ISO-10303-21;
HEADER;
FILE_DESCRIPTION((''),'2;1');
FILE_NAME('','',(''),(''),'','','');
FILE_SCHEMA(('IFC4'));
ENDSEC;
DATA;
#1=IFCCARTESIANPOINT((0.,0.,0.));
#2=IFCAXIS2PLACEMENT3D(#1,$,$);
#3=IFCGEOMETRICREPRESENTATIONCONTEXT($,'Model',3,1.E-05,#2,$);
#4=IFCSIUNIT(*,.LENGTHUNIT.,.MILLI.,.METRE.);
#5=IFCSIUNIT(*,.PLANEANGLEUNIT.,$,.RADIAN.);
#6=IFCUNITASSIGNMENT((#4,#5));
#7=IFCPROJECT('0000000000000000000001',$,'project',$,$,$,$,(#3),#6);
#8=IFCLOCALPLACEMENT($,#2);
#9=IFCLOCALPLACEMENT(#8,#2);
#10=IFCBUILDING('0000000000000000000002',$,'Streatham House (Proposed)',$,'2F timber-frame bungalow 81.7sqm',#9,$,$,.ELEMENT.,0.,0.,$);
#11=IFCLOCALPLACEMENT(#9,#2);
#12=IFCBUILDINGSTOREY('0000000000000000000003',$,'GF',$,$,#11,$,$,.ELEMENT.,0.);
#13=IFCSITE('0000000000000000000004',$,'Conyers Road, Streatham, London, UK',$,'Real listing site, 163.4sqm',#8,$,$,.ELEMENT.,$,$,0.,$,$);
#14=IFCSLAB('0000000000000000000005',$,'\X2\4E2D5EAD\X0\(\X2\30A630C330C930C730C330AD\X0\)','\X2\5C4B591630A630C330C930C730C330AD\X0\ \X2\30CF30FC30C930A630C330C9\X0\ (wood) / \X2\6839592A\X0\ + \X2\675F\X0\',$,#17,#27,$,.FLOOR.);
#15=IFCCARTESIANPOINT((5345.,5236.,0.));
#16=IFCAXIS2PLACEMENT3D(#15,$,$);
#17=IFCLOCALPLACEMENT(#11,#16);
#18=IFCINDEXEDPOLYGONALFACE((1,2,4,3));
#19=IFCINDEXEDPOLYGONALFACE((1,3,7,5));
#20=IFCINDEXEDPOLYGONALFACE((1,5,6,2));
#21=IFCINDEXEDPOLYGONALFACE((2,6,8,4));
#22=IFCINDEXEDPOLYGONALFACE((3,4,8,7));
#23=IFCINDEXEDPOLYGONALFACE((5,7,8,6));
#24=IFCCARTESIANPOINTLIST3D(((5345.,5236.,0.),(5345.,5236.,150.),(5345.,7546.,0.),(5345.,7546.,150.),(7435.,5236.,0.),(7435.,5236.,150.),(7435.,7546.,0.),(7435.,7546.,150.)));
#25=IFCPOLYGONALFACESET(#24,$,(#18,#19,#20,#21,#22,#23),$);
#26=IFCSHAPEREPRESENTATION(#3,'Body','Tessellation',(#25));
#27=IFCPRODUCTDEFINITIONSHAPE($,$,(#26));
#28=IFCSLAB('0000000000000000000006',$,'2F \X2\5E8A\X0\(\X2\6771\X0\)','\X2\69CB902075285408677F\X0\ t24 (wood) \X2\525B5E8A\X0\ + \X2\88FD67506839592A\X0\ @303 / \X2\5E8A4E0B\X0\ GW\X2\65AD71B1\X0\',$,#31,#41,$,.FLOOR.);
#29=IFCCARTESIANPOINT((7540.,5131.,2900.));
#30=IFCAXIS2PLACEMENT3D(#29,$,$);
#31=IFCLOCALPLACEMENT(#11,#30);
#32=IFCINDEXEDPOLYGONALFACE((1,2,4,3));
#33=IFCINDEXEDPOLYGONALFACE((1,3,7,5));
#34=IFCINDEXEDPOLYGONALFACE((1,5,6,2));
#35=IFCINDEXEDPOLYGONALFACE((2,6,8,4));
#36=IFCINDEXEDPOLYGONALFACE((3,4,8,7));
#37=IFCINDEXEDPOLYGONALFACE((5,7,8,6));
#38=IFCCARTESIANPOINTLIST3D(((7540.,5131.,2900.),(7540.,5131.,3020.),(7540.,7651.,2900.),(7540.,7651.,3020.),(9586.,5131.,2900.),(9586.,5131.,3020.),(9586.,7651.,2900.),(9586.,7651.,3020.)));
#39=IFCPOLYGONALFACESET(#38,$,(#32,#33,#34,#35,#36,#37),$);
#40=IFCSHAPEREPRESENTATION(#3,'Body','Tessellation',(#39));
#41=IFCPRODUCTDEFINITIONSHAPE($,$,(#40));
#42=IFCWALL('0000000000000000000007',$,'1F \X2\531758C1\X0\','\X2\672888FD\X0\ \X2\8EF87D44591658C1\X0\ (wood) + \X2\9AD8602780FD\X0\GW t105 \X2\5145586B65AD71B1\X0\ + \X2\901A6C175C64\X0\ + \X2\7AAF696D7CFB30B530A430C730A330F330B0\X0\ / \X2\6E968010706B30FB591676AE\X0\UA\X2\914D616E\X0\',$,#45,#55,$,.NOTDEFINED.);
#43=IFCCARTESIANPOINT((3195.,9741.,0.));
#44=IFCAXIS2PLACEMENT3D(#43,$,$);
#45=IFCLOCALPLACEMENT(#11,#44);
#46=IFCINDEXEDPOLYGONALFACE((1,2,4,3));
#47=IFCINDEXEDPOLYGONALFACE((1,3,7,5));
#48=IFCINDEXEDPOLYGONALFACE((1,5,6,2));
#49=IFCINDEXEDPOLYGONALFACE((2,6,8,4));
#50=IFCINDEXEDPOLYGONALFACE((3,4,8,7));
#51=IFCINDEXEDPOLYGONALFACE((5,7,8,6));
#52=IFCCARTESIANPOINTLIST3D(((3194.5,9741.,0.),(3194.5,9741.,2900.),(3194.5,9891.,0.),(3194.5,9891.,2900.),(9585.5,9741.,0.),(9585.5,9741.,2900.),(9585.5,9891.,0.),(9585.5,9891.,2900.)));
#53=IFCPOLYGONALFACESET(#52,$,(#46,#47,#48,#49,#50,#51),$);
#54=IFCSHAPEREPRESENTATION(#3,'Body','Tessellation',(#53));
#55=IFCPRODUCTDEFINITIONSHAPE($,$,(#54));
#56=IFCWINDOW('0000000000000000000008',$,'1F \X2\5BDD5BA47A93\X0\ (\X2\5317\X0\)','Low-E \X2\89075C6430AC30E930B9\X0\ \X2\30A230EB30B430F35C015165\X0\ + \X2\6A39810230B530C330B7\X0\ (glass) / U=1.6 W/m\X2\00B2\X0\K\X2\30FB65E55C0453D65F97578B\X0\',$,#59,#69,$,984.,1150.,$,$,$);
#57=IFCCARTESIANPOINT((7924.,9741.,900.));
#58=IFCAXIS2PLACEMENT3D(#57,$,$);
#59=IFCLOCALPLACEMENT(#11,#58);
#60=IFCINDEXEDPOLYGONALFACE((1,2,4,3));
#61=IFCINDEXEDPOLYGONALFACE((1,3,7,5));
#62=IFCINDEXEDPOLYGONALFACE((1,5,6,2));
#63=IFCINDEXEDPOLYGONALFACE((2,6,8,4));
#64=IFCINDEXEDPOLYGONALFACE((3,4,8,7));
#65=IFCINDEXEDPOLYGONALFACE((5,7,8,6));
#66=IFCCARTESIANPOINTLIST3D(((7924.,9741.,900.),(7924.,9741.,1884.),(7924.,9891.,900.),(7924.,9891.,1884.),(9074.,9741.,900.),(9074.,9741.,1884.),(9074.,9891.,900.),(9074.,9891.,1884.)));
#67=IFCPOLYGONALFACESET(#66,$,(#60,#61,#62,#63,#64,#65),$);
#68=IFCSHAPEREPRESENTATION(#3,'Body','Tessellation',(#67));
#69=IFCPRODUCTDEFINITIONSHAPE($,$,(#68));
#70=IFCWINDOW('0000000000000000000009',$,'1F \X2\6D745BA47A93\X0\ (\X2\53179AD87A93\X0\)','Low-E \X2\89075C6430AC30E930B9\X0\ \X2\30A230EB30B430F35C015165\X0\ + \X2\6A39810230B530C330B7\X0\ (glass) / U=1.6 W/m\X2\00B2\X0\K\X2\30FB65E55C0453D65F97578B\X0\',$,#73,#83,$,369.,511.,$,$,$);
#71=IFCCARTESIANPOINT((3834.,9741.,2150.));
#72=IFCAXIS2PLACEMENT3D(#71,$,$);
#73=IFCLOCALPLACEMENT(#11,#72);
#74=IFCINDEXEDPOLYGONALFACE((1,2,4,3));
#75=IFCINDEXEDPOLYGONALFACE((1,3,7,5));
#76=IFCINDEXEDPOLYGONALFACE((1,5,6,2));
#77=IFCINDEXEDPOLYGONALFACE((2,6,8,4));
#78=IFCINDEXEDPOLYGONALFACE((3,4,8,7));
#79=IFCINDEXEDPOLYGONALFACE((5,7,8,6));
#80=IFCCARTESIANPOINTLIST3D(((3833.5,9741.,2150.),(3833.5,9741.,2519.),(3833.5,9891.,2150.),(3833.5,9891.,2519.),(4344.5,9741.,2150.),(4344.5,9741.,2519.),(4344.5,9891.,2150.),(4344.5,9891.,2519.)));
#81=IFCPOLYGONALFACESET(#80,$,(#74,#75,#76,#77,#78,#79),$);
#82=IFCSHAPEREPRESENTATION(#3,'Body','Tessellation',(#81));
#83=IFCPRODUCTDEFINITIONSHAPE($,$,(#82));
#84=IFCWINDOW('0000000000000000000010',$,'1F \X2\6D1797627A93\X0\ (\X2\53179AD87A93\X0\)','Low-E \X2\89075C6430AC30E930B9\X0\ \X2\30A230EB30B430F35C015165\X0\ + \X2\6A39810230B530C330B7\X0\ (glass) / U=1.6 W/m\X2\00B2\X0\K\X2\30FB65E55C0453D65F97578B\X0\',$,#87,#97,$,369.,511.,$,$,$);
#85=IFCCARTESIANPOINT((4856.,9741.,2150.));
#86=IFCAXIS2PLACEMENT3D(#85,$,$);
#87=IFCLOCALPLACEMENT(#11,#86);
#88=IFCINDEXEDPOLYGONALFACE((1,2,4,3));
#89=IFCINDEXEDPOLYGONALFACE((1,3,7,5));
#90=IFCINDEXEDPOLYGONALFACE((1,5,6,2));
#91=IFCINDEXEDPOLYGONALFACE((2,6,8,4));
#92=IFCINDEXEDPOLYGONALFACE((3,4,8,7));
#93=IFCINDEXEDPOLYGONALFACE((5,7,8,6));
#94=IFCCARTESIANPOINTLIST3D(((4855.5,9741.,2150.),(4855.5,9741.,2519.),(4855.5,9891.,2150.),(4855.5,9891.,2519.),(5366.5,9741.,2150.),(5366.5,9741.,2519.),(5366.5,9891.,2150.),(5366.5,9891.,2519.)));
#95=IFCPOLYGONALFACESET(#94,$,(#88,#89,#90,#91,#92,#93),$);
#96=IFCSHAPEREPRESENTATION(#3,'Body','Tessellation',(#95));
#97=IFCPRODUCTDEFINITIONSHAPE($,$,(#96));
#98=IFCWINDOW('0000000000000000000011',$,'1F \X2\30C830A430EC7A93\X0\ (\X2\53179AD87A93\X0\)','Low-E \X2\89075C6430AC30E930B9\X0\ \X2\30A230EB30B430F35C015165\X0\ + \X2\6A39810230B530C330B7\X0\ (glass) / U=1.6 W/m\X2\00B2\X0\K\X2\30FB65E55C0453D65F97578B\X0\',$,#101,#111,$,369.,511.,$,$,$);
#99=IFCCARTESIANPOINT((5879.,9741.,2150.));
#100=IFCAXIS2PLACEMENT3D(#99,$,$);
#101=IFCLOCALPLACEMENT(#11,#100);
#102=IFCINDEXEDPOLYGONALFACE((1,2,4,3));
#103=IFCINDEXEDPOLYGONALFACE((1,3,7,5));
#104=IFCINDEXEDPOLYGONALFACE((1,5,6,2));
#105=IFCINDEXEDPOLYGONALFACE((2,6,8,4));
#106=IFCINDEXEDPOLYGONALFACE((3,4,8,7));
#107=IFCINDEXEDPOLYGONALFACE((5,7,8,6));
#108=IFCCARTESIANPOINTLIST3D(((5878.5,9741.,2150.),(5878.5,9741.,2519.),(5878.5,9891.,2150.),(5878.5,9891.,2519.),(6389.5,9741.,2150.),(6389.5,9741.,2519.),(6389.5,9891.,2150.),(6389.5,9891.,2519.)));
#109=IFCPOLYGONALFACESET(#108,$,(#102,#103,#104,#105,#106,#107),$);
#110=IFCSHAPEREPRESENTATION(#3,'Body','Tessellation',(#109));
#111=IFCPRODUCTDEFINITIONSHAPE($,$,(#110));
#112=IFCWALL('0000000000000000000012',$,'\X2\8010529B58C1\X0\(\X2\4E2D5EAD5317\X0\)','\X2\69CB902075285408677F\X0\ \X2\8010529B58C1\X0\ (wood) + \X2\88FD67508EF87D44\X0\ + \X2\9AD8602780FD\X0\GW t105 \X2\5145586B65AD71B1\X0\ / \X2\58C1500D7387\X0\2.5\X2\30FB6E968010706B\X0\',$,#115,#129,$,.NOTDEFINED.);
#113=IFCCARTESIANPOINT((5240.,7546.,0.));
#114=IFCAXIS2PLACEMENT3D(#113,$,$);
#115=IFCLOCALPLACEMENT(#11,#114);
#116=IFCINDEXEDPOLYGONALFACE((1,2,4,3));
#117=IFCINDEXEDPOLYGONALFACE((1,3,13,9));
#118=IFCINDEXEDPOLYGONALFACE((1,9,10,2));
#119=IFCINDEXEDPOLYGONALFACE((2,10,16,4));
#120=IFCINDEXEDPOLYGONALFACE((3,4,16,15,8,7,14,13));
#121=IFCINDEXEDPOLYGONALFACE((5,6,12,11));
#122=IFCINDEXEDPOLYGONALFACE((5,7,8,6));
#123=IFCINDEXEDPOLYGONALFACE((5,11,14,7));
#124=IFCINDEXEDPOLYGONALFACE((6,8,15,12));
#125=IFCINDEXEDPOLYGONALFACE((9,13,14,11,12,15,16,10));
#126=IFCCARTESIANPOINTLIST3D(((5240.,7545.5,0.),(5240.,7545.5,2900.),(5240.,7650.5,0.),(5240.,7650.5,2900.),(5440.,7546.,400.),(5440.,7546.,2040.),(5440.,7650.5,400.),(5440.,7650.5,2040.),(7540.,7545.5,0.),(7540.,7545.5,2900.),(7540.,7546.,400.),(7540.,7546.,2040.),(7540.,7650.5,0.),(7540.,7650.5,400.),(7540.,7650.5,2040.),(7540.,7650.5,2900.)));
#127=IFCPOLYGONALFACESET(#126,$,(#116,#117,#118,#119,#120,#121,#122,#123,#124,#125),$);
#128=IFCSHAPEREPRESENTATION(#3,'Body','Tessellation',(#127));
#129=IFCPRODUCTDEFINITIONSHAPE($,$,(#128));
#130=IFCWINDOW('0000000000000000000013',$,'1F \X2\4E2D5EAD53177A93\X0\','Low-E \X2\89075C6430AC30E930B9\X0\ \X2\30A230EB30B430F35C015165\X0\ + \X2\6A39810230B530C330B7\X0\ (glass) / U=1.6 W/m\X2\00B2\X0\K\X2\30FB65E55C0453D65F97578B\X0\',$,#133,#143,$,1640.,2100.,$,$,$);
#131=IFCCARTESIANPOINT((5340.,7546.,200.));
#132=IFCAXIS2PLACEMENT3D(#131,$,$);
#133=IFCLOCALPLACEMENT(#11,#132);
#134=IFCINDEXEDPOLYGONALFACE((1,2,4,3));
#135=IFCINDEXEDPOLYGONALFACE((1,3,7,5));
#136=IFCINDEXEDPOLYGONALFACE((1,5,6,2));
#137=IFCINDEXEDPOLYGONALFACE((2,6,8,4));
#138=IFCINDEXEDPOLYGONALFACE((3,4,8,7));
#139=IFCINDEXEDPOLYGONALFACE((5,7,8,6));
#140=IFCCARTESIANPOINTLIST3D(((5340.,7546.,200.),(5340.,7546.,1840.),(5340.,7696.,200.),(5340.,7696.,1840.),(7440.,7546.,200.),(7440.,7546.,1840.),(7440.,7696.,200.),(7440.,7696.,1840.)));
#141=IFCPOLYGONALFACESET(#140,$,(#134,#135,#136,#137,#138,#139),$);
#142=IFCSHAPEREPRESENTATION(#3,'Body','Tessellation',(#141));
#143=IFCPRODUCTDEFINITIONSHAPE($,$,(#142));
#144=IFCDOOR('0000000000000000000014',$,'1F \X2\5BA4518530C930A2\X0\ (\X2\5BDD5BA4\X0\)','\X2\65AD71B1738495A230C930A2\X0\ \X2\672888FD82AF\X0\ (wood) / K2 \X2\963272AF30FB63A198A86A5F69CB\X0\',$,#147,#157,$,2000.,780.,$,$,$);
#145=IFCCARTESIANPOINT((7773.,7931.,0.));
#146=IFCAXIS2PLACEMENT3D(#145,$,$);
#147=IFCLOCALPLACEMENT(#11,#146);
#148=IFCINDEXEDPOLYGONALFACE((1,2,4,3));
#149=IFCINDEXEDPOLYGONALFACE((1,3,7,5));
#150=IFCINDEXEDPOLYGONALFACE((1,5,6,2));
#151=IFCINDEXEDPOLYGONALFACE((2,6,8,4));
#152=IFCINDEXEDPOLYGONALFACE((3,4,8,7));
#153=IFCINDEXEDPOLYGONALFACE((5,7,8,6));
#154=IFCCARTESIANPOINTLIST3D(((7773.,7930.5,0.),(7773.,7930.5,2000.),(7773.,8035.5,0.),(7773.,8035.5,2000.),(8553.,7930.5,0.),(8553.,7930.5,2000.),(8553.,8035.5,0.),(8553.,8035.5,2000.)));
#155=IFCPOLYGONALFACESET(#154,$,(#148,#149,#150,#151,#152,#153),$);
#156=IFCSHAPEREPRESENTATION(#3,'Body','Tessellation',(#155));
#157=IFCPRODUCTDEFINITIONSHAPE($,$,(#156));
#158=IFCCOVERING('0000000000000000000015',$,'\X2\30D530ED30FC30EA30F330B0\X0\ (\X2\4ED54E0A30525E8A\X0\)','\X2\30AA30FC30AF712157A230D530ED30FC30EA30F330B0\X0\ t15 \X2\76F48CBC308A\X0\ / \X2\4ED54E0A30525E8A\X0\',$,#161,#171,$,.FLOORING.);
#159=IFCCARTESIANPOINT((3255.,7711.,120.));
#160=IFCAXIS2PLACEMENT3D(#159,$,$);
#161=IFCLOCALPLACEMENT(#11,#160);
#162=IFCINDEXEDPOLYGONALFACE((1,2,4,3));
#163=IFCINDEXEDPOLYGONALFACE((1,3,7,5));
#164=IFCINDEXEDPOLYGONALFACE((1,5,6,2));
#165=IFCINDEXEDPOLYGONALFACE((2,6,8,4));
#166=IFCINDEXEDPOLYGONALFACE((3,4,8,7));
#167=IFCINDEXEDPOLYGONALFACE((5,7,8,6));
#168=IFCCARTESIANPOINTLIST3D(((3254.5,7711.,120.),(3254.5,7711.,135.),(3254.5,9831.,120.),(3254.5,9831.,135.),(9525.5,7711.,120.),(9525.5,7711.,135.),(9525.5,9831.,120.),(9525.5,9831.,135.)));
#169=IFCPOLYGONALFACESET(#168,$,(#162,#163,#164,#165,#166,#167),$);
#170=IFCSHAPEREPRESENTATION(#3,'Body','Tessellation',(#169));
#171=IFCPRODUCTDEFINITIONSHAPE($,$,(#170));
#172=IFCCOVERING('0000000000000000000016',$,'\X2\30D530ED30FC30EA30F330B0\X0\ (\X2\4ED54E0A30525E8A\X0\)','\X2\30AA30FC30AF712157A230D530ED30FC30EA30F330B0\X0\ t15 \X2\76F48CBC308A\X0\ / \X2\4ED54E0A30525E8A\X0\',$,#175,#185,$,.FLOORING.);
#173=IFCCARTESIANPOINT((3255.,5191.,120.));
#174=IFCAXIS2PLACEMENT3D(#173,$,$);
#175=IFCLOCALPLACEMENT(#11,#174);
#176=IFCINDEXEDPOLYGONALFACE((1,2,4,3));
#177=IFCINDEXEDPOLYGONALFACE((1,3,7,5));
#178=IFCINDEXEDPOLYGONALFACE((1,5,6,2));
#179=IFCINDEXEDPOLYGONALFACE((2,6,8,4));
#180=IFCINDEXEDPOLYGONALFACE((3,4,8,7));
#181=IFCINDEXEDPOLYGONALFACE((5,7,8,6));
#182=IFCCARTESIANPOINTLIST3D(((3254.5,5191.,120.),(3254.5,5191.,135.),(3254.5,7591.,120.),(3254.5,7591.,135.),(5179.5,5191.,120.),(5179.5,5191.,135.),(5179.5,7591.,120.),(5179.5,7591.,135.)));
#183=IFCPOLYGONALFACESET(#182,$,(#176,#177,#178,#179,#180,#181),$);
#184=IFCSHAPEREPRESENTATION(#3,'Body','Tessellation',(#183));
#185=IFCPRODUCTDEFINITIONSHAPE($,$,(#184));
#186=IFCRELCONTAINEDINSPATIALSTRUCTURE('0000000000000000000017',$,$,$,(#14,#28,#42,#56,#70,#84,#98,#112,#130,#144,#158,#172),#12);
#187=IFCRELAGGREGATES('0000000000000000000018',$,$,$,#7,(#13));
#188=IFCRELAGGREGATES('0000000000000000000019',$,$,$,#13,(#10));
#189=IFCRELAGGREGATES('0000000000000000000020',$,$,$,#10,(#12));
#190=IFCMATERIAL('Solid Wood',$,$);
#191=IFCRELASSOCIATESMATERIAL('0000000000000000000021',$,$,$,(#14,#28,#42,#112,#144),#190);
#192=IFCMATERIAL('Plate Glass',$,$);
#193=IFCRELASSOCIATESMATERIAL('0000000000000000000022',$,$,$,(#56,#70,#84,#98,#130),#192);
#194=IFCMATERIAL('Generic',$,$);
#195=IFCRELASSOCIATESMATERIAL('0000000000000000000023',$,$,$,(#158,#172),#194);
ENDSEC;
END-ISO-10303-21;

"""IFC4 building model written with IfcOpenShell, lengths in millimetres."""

from ifc_helpers import new_model, si_unit, frame, frame_2d, origin, place, context, project, spatial, rectangle, extrude, material, element, fill, save


model = new_model("IFC4")

# Units and contexts
model_context = context("Model", 3, precision=1e-05, world=origin())
ifc_project = project(units=[si_unit("LENGTHUNIT", "METRE", prefix="MILLI"), si_unit("PLANEANGLEUNIT", "RADIAN")], contexts=[model_context])

# Site, building, storey
site_placement = place(None, origin())
site = spatial("IfcSite", under=ifc_project, at=site_placement, Name="Conyers Road, Streatham, London, UK", ObjectType="Real listing site, 163.4sqm", CompositionType="ELEMENT", RefElevation=0.0)
building_placement = place(site_placement, origin())
building = spatial("IfcBuilding", under=site, at=building_placement, Name="Streatham House (Proposed)", ObjectType="2F timber-frame bungalow 81.7sqm", CompositionType="ELEMENT", ElevationOfRefHeight=0.0, ElevationOfTerrain=0.0)
storey_placement = place(building_placement, origin())
storey = spatial("IfcBuildingStorey", under=building, at=storey_placement, Name="GF", CompositionType="ELEMENT", Elevation=0.0)

# Slabs
ifc_material_1 = material(Name="Solid Wood")
slab_1_placement = place(storey_placement, frame((5345.0, 5236.0, 0.0)))
element("IfcSlab", 1, at=slab_1_placement, inside=storey, material=ifc_material_1, Name="中庭(ウッドデッキ)", Description="屋外ウッドデッキ ハードウッド (wood) / 根太 + 束", PredefinedType="FLOOR", context=model_context, shape_type="SweptSolid", body=[
    extrude(rectangle(XDim=2090.0, YDim=2310.0, at=frame_2d((1045.0, 1155.0))), frame((5345.0, 5236.0, 0.0)), (0.0, 0.0, 1.0), 150.0),
])
slab_2_placement = place(storey_placement, frame((7540.0, 5131.0, 2900.0)))
element("IfcSlab", 2, at=slab_2_placement, inside=storey, material=ifc_material_1, Name="2F 床(東)", Description="構造用合板 t24 (wood) 剛床 + 製材根太 @303 / 床下 GW断熱", PredefinedType="FLOOR", context=model_context, shape_type="SweptSolid", body=[
    extrude(rectangle(XDim=2046.0, YDim=2520.0, at=frame_2d((1023.0, 1260.0))), frame((7540.0, 5131.0, 2900.0)), (0.0, 0.0, 1.0), 120.0),
])

# Wall, openings, windows
wall_1_placement = place(storey_placement, frame((3195.0, 9741.0, 0.0)))
wall_1 = element("IfcWall", 3, at=wall_1_placement, inside=storey, material=ifc_material_1, Name="1F 北壁", Description="木製 軸組外壁 (wood) + 高性能GW t105 充填断熱 + 通気層 + 窯業系サイディング / 準耐火・外皮UA配慮", PredefinedType="NOTDEFINED", context=model_context, shape_type="SweptSolid", body=[
    extrude(rectangle(XDim=6391.0, YDim=150.0, at=frame_2d((3195.0, 75.0))), frame((3195.0, 9741.0, 0.0)), (0.0, 0.0, 1.0), 2900.0),
])
opening_1_placement = place(storey_placement, frame((7924.0, 9741.0, 900.0)))
opening_1 = element("IfcOpeningElement", 4, at=opening_1_placement, cuts=wall_1, PredefinedType="NOTDEFINED", context=model_context, shape_type="SweptSolid", body=[
    extrude(rectangle(XDim=1150.0, YDim=150.0, at=frame_2d((575.0, 75.0))), frame((7924.0, 9741.0, 900.0)), (0.0, 0.0, 1.0), 984.0),
])
opening_2_placement = place(storey_placement, frame((3834.0, 9741.0, 2150.0)))
opening_2 = element("IfcOpeningElement", 5, at=opening_2_placement, cuts=wall_1, PredefinedType="NOTDEFINED", context=model_context, shape_type="SweptSolid", body=[
    extrude(rectangle(XDim=511.0, YDim=150.0, at=frame_2d((255.0, 75.0))), frame((3834.0, 9741.0, 2150.0)), (0.0, 0.0, 1.0), 369.0),
])
opening_3_placement = place(storey_placement, frame((4856.0, 9741.0, 2150.0)))
opening_3 = element("IfcOpeningElement", 6, at=opening_3_placement, cuts=wall_1, PredefinedType="NOTDEFINED", context=model_context, shape_type="SweptSolid", body=[
    extrude(rectangle(XDim=511.0, YDim=150.0, at=frame_2d((255.0, 75.0))), frame((4856.0, 9741.0, 2150.0)), (0.0, 0.0, 1.0), 369.0),
])
opening_4_placement = place(storey_placement, frame((5879.0, 9741.0, 2150.0)))
opening_4 = element("IfcOpeningElement", 7, at=opening_4_placement, cuts=wall_1, PredefinedType="NOTDEFINED", context=model_context, shape_type="SweptSolid", body=[
    extrude(rectangle(XDim=511.0, YDim=150.0, at=frame_2d((255.0, 75.0))), frame((5879.0, 9741.0, 2150.0)), (0.0, 0.0, 1.0), 369.0),
])
ifc_material_2 = material(Name="Plate Glass")
window_1_placement = place(storey_placement, frame((7924.0, 9741.0, 900.0)))
window_1 = element("IfcWindow", 8, at=window_1_placement, inside=storey, material=ifc_material_2, Name="1F 寝室窓 (北)", Description="Low-E 複層ガラス アルゴン封入 + 樹脂サッシ (glass) / U=1.6 W/m²K・日射取得型", OverallHeight=984.0, OverallWidth=1150.0, context=model_context, shape_type="SweptSolid", body=[
    extrude(rectangle(XDim=1150.0, YDim=150.0, at=frame_2d((575.0, 75.0))), frame((7924.0, 9741.0, 900.0)), (0.0, 0.0, 1.0), 984.0),
])
fill(opening_1, window_1)
window_2_placement = place(storey_placement, frame((3834.0, 9741.0, 2150.0)))
window_2 = element("IfcWindow", 9, at=window_2_placement, inside=storey, material=ifc_material_2, Name="1F 浴室窓 (北高窓)", Description="Low-E 複層ガラス アルゴン封入 + 樹脂サッシ (glass) / U=1.6 W/m²K・日射取得型", OverallHeight=369.0, OverallWidth=511.0, context=model_context, shape_type="SweptSolid", body=[
    extrude(rectangle(XDim=511.0, YDim=150.0, at=frame_2d((255.0, 75.0))), frame((3834.0, 9741.0, 2150.0)), (0.0, 0.0, 1.0), 369.0),
])
fill(opening_2, window_2)
window_3_placement = place(storey_placement, frame((4856.0, 9741.0, 2150.0)))
window_3 = element("IfcWindow", 10, at=window_3_placement, inside=storey, material=ifc_material_2, Name="1F 洗面窓 (北高窓)", Description="Low-E 複層ガラス アルゴン封入 + 樹脂サッシ (glass) / U=1.6 W/m²K・日射取得型", OverallHeight=369.0, OverallWidth=511.0, context=model_context, shape_type="SweptSolid", body=[
    extrude(rectangle(XDim=511.0, YDim=150.0, at=frame_2d((255.0, 75.0))), frame((4856.0, 9741.0, 2150.0)), (0.0, 0.0, 1.0), 369.0),
])
fill(opening_3, window_3)
window_4_placement = place(storey_placement, frame((5879.0, 9741.0, 2150.0)))
window_4 = element("IfcWindow", 11, at=window_4_placement, inside=storey, material=ifc_material_2, Name="1F トイレ窓 (北高窓)", Description="Low-E 複層ガラス アルゴン封入 + 樹脂サッシ (glass) / U=1.6 W/m²K・日射取得型", OverallHeight=369.0, OverallWidth=511.0, context=model_context, shape_type="SweptSolid", body=[
    extrude(rectangle(XDim=511.0, YDim=150.0, at=frame_2d((255.0, 75.0))), frame((5879.0, 9741.0, 2150.0)), (0.0, 0.0, 1.0), 369.0),
])
fill(opening_4, window_4)

# Wall, opening, window
wall_2_placement = place(storey_placement, frame((5240.0, 7546.0, 0.0)))
wall_2 = element("IfcWall", 12, at=wall_2_placement, inside=storey, material=ifc_material_1, Name="耐力壁(中庭北)", Description="構造用合板 耐力壁 (wood) + 製材軸組 + 高性能GW t105 充填断熱 / 壁倍率2.5・準耐火", PredefinedType="NOTDEFINED", context=model_context, shape_type="SweptSolid", body=[
    extrude(rectangle(XDim=2300.0, YDim=105.0, at=frame_2d((1150.0, 52.0))), frame((5240.0, 7546.0, 0.0)), (0.0, 0.0, 1.0), 2900.0),
])
opening_5_placement = place(storey_placement, frame((5340.0, 7546.0, 200.0)))
opening_5 = element("IfcOpeningElement", 13, at=opening_5_placement, cuts=wall_2, PredefinedType="NOTDEFINED", context=model_context, shape_type="SweptSolid", body=[
    extrude(rectangle(XDim=2100.0, YDim=150.0, at=frame_2d((1050.0, 75.0))), frame((5340.0, 7546.0, 200.0)), (0.0, 0.0, 1.0), 1640.0),
])
window_5_placement = place(storey_placement, frame((5340.0, 7546.0, 200.0)))
window_5 = element("IfcWindow", 14, at=window_5_placement, inside=storey, material=ifc_material_2, Name="1F 中庭北窓", Description="Low-E 複層ガラス アルゴン封入 + 樹脂サッシ (glass) / U=1.6 W/m²K・日射取得型", OverallHeight=1640.0, OverallWidth=2100.0, context=model_context, shape_type="SweptSolid", body=[
    extrude(rectangle(XDim=2100.0, YDim=150.0, at=frame_2d((1050.0, 75.0))), frame((5340.0, 7546.0, 200.0)), (0.0, 0.0, 1.0), 1640.0),
])
fill(opening_5, window_5)

# Door
door_1_placement = place(storey_placement, frame((7773.0, 7931.0, 0.0)))
element("IfcDoor", 15, at=door_1_placement, inside=storey, material=ifc_material_1, Name="1F 室内ドア (寝室)", Description="断熱玄関ドア 木製芯 (wood) / K2 防犯・採風機構", OverallHeight=2000.0, OverallWidth=780.0, context=model_context, shape_type="SweptSolid", body=[
    extrude(rectangle(XDim=780.0, YDim=105.0, at=frame_2d((390.0, 52.0))), frame((7773.0, 7931.0, 0.0)), (0.0, 0.0, 1.0), 2000.0),
])

# Coverings
ifc_material_3 = material(Name="Generic")
covering_1_placement = place(storey_placement, frame((3255.0, 7711.0, 120.0)))
element("IfcCovering", 16, at=covering_1_placement, inside=storey, material=ifc_material_3, Name="フローリング (仕上げ床)", Description="オーク無垢フローリング t15 直貼り / 仕上げ床", PredefinedType="FLOORING", context=model_context, shape_type="SweptSolid", body=[
    extrude(rectangle(XDim=6271.0, YDim=2120.0, at=frame_2d((3135.0, 1060.0))), frame((3255.0, 7711.0, 120.0)), (0.0, 0.0, 1.0), 15.0),
])
covering_2_placement = place(storey_placement, frame((3255.0, 5191.0, 120.0)))
element("IfcCovering", 17, at=covering_2_placement, inside=storey, material=ifc_material_3, Name="フローリング (仕上げ床)", Description="オーク無垢フローリング t15 直貼り / 仕上げ床", PredefinedType="FLOORING", context=model_context, shape_type="SweptSolid", body=[
    extrude(rectangle(XDim=1925.0, YDim=2400.0, at=frame_2d((962.0, 1200.0))), frame((3255.0, 5191.0, 120.0)), (0.0, 0.0, 1.0), 15.0),
])

save(model, "model.ifc")
